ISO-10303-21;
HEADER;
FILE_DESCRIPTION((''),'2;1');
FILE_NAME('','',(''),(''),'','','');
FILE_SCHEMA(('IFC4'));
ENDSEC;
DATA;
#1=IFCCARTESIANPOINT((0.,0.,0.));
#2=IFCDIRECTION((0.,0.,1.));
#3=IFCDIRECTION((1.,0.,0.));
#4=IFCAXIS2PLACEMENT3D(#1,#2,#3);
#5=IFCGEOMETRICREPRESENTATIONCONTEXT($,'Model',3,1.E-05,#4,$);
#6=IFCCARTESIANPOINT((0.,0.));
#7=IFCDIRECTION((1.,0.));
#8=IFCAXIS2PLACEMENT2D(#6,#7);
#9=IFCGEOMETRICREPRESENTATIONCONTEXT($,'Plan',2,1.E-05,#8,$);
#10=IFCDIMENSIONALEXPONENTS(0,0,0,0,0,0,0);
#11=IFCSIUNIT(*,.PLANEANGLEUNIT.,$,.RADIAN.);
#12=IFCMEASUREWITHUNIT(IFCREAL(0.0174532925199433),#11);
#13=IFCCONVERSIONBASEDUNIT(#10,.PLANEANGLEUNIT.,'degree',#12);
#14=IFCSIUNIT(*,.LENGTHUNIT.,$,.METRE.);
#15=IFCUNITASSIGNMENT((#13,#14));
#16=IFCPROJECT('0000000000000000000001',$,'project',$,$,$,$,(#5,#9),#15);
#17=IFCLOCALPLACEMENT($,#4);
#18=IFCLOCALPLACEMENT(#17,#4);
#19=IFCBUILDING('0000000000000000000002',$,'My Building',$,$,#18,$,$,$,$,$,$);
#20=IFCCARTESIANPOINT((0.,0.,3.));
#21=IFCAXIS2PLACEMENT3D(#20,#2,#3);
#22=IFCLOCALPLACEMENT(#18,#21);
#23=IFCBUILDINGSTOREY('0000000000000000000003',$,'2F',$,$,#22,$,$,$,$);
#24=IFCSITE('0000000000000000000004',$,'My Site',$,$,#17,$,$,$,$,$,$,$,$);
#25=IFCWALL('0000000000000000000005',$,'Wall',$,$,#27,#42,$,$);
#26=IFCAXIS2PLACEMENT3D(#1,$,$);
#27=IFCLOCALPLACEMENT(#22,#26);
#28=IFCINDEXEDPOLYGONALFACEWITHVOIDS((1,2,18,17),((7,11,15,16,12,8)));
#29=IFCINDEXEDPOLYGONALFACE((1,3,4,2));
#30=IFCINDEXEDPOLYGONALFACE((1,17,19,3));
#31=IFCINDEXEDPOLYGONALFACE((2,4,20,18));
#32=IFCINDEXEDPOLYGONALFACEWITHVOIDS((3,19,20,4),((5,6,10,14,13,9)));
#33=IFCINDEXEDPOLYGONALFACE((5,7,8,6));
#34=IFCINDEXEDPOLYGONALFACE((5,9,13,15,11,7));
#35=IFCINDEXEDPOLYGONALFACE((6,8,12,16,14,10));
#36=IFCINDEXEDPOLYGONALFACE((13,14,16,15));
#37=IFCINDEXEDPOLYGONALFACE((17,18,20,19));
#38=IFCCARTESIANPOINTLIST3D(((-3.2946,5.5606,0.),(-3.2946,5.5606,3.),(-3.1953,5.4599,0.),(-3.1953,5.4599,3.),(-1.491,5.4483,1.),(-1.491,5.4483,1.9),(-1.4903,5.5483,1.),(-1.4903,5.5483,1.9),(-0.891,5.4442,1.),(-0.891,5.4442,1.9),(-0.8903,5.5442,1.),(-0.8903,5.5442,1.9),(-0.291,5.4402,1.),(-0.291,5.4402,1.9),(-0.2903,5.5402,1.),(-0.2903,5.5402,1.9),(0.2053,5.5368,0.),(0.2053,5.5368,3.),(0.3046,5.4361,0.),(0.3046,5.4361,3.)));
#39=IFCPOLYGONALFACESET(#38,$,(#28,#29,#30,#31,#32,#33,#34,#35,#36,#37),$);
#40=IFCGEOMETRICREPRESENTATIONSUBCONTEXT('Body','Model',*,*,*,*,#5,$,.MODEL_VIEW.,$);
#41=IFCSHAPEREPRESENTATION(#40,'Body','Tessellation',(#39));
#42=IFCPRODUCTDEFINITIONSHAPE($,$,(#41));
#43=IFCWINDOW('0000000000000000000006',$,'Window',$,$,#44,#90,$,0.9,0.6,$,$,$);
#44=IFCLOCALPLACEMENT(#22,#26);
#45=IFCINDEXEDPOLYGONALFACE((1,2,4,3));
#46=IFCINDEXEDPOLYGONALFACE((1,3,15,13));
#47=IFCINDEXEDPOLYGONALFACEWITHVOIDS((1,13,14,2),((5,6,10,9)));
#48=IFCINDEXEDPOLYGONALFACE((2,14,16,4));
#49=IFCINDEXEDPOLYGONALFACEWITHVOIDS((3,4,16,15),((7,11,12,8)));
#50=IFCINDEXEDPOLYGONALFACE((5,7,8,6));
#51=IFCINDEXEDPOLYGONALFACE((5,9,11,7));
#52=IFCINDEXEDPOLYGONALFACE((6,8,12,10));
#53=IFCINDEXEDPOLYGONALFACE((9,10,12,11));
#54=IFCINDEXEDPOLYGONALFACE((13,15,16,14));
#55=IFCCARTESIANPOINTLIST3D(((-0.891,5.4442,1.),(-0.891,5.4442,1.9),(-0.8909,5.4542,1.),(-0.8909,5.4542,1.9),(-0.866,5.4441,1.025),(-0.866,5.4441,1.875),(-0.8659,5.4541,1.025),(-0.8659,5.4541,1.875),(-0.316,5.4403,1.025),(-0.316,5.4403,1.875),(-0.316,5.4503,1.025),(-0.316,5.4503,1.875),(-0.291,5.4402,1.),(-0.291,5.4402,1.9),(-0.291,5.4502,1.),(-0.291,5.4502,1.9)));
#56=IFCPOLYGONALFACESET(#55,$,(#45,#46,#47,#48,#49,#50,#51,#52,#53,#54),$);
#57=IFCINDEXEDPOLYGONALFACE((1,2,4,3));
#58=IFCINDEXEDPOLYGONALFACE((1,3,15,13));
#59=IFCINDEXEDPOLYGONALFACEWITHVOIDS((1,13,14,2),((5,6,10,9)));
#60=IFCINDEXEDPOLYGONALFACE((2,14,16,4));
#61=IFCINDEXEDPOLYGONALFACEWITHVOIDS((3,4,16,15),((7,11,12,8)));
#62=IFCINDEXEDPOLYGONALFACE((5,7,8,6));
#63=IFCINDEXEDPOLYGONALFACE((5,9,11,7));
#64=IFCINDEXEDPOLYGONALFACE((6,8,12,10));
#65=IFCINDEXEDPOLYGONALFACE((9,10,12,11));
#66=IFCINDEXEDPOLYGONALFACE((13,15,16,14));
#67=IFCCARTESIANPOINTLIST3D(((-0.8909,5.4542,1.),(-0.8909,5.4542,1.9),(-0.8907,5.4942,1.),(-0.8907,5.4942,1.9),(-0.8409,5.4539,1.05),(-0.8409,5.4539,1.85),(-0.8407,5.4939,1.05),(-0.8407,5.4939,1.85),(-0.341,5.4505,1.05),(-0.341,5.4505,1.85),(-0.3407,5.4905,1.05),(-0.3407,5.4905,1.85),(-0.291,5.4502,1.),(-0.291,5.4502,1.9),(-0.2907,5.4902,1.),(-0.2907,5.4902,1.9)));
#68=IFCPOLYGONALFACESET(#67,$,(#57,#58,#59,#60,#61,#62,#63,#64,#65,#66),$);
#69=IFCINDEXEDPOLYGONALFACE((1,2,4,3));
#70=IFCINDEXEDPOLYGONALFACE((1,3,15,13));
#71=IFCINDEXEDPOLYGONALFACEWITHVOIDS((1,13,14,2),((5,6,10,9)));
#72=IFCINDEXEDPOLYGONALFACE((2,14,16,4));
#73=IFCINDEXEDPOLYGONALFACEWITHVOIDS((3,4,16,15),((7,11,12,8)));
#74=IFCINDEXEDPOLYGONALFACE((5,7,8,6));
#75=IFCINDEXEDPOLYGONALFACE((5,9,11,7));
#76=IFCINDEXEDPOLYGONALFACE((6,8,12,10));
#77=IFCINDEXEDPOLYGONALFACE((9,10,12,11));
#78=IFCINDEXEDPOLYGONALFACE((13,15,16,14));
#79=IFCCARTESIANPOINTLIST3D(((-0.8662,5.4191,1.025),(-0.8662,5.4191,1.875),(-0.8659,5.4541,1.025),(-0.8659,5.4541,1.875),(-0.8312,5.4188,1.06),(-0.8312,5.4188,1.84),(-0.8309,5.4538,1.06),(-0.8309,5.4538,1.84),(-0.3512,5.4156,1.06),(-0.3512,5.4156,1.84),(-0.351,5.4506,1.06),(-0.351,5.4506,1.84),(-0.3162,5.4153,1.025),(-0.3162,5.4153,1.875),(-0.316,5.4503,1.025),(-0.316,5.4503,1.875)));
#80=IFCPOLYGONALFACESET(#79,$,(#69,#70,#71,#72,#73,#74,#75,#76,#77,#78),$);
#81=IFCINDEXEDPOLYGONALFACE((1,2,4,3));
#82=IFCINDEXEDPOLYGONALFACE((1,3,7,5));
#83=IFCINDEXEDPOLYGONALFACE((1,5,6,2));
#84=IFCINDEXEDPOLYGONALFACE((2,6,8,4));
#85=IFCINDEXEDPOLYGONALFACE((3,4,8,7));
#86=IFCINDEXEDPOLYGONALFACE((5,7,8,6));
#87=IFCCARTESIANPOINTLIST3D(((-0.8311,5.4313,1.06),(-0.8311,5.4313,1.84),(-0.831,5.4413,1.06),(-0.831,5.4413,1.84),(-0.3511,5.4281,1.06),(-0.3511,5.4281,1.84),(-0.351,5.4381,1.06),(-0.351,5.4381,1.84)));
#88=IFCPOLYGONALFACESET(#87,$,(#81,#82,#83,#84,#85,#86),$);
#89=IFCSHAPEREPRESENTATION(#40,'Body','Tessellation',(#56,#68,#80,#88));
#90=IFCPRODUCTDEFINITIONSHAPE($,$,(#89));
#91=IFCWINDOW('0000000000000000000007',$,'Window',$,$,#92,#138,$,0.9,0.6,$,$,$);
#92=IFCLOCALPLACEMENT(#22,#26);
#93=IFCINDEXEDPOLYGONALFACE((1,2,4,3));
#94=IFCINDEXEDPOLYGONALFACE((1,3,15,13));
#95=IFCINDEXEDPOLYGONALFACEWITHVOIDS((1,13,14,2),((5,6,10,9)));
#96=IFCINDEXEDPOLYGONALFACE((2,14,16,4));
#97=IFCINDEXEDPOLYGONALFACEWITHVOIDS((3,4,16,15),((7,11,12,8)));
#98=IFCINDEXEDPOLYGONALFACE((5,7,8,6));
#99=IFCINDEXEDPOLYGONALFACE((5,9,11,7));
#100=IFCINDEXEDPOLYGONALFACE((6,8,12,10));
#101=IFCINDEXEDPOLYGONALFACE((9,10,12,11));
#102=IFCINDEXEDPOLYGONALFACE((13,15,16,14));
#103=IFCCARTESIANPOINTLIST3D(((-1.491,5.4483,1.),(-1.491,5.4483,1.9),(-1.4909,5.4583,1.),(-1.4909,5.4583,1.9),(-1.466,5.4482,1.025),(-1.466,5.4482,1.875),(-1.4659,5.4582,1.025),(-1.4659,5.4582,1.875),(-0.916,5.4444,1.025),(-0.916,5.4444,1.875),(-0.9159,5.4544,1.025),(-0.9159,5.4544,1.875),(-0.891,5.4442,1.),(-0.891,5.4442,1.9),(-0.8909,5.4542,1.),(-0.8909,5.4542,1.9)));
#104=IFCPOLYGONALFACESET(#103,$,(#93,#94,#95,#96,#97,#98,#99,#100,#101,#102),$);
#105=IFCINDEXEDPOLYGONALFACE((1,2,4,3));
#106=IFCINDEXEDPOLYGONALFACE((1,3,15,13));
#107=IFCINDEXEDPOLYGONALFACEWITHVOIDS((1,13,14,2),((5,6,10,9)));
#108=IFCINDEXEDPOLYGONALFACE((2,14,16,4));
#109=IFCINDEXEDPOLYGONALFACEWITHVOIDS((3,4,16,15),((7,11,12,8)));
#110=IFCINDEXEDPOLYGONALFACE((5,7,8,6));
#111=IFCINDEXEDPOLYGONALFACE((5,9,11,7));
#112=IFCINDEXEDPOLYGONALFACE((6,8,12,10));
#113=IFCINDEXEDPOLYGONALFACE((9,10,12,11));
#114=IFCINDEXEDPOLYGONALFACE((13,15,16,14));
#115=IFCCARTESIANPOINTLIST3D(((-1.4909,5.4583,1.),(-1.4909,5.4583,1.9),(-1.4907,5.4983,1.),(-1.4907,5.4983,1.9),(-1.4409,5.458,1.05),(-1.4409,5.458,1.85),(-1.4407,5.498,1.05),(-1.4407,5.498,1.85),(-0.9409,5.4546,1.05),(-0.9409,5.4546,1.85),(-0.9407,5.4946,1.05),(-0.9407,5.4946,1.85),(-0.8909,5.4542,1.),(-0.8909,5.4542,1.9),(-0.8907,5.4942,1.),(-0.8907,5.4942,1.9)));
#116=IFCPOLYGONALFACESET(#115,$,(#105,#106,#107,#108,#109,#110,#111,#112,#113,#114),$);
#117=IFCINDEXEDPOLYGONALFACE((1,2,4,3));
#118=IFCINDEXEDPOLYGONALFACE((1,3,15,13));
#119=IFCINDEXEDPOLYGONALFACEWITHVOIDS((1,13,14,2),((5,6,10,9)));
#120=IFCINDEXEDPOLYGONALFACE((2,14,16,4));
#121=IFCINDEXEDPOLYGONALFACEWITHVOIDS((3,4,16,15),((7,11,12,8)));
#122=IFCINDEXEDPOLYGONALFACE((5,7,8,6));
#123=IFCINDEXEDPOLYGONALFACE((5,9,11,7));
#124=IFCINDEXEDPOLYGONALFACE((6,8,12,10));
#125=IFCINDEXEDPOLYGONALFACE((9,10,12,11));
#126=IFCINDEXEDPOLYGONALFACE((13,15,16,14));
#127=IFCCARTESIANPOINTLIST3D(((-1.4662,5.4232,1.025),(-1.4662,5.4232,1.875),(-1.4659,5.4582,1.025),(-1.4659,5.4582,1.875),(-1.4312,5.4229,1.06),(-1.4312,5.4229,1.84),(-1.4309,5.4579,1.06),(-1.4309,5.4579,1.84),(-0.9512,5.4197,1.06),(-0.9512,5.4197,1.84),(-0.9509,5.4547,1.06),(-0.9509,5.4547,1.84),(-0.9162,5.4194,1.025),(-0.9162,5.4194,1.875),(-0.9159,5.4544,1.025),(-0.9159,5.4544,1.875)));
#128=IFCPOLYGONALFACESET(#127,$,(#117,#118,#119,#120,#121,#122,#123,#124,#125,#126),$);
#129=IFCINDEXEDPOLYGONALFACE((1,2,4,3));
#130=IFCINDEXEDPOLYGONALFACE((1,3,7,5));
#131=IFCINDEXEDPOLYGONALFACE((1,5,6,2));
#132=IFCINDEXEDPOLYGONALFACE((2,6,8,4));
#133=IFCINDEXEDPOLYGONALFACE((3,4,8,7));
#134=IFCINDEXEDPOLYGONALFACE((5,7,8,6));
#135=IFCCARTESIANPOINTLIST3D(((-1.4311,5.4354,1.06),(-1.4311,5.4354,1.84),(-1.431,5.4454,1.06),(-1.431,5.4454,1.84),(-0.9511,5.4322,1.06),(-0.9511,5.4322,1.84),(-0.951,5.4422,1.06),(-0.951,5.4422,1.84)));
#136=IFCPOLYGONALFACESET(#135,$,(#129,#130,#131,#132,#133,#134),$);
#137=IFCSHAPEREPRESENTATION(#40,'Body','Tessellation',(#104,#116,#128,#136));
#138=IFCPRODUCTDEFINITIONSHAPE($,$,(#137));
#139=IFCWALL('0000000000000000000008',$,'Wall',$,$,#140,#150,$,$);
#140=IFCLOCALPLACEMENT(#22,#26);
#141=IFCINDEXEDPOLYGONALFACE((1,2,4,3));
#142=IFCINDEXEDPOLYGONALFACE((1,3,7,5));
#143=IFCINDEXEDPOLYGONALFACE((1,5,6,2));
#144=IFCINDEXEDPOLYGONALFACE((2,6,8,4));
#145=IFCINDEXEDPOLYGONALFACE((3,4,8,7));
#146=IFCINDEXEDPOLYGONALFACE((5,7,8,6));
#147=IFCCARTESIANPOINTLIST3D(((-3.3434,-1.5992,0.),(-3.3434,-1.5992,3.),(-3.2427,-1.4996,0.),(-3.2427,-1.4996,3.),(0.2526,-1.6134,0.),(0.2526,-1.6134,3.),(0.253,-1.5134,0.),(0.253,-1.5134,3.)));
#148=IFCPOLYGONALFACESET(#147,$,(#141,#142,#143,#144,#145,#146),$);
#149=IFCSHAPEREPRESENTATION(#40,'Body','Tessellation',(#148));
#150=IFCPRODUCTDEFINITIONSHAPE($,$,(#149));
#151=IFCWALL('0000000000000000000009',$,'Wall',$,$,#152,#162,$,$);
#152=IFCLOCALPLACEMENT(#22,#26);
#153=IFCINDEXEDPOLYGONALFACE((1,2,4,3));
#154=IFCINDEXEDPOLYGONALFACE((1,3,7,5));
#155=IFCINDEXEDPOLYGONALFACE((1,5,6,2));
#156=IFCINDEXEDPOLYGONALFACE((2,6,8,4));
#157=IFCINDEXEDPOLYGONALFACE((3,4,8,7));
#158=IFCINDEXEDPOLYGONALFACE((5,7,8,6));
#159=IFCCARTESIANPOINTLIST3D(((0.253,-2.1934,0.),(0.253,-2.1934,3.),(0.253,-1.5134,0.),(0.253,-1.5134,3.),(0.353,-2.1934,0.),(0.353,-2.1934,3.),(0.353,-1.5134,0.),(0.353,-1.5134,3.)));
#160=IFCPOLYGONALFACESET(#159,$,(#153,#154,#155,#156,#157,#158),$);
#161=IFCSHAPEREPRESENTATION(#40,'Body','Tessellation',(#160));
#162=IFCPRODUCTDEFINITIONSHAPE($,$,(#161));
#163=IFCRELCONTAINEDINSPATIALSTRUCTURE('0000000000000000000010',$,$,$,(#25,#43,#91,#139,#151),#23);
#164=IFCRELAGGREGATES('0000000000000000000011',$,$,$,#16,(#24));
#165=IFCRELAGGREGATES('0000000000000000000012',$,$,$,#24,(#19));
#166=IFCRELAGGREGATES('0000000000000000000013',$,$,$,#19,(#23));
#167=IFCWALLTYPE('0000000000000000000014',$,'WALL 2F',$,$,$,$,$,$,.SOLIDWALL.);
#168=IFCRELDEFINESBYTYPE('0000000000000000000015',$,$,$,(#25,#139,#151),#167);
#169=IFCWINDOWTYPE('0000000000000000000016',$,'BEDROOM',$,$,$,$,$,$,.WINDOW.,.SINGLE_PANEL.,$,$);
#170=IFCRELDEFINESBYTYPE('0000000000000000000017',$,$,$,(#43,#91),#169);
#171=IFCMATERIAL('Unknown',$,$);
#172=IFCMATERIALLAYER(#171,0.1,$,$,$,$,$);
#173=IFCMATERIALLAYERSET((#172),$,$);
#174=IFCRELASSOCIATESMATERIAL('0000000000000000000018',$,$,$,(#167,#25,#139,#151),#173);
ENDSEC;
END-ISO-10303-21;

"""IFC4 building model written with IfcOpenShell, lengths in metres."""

from ifc_helpers import new_model, entity, si_unit, converted_unit, frame, origin_with_axes, origin_2d_with_axis, place, context, subcontext, project, spatial, line, indexed_curve, outline, extrude, shape, source, transform, mapped, material, layer, layer_set, layer_usage, type_object, type_shapes, element, fill, save


model = new_model("IFC4")

# Units and contexts
model_context = context("Model", 3, precision=1e-05, world=origin_with_axes())
plan_context = context("Plan", 2, precision=1e-05, world=origin_2d_with_axis())
body_context_1 = subcontext(model_context, "Body", "Model", "MODEL_VIEW")
body_context_2 = subcontext(plan_context, "Body", "Plan", "PLAN_VIEW")
ifc_project = project(units=[converted_unit("PLANEANGLEUNIT", "degree", entity("IfcReal", 0.0174532925199433), si_unit("PLANEANGLEUNIT", "RADIAN"), dimensions=[0, 0, 0, 0, 0, 0, 0]), si_unit("LENGTHUNIT", "METRE")], contexts=[model_context, plan_context])

# Site, building, storey
site_placement = place(None, origin_with_axes())
site = spatial("IfcSite", under=ifc_project, at=site_placement, Name="My Site")
building_placement = place(site_placement, origin_with_axes())
building = spatial("IfcBuilding", under=site, at=building_placement, Name="My Building")
storey_placement = place(building_placement, frame((0.0, 0.0, 3.0), z_axis=(0.0, 0.0, 1.0), x_axis=(1.0, 0.0, 0.0)))
storey = spatial("IfcBuildingStorey", under=building, at=storey_placement, Name="2F")

# Shared definitions
ifc_material = material(Name="Unknown")

# Shared definitions
ifc_layer_1 = layer(ifc_material, 0.1)
ifc_layer_set_1 = layer_set([ifc_layer_1])
wall_type = type_object("IfcWallType", Name="WALL 2F", PredefinedType="SOLIDWALL", material=ifc_layer_set_1)

# Wall, openings, windows
ifc_layer_usage_1 = layer_usage(ifc_layer_set_1, "AXIS2", "POSITIVE", 0.0)
wall_1_placement = place(storey_placement, frame((0.2053, 5.5368, 0.0), z_axis=(0.0, 0.0, 1.0), x_axis=(-0.999977, 0.006815, 0.0)))
wall_1 = element("IfcWall", 1, at=wall_1_placement, inside=storey, type_object=wall_type, material=ifc_layer_usage_1, Name="Wall", context=body_context_1, shape_type="SweptSolid", body=[
    extrude(outline(indexed_curve([(0.0, 0.0), (-0.1, 0.1), (3.4, 0.1), (3.5, 0.0)], segments=[line(1, 2, 3, 4, 1)])), origin_with_axes(), (0.0, 0.0, 1.0), 3.0),
])
shared_shape_1 = source(origin_with_axes(), body_context_1, "Body", "SweptSolid", [
    extrude(outline(indexed_curve([(0.0, 0.0), (0.6, 0.0), (0.6, 0.9), (0.0, 0.9)], segments=[line(1, 2, 3, 4, 1)])), frame((0.0, -0.6, 0.0), z_axis=(0.0, -1.0, 0.0), x_axis=(1.0, 0.0, 0.0)), (0.0, 0.0, -1.0), 1.2),
])
opening_1_placement = place(wall_1_placement, frame((0.4957, 0.0, 1.0), z_axis=(0.0, 0.0, 1.0), x_axis=(1.0, 0.0, 0.0)))
opening_1 = element("IfcOpeningElement", 2, at=opening_1_placement, cuts=wall_1, PredefinedType="OPENING", context=body_context_1, shape_type="MappedRepresentation", body=[
    mapped(shared_shape_1, transform((0.0, 0.0, 0.0), x_axis=(1.0, 0.0, 0.0), y_axis=(0.0, 1.0, 0.0), z_axis=(0.0, 0.0, 1.0), scale=1.0)),
])
opening_2_placement = place(wall_1_placement, frame((1.0957, 0.0, 1.0), z_axis=(0.0, 0.0, 1.0), x_axis=(1.0, 0.0, 0.0)))
opening_2 = element("IfcOpeningElement", 3, at=opening_2_placement, cuts=wall_1, PredefinedType="OPENING", context=body_context_1, shape_type="MappedRepresentation", body=[
    mapped(shared_shape_1, transform((0.0, 0.0, 0.0), x_axis=(1.0, 0.0, 0.0), y_axis=(0.0, 1.0, 0.0), z_axis=(0.0, 0.0, 1.0), scale=1.0)),
])
window_type_1 = type_object("IfcWindowType", Name="BEDROOM", PartitioningType="SINGLE_PANEL", PredefinedType="WINDOW")
shared_shape_2 = source(origin_with_axes(), body_context_1, "Body", "SweptSolid", [
    extrude(outline(indexed_curve([(0.0, 0.0), (0.6, 0.0), (0.6, 0.9), (0.0, 0.9)], segments=[line(1, 2, 3, 4, 1)]), holes=[indexed_curve([(0.025, 0.025), (0.575, 0.025), (0.575, 0.875), (0.025, 0.875)], segments=[line(1, 2, 3, 4, 1)])]), frame((0.0, 0.09, 0.0), z_axis=(0.0, -1.0, 0.0), x_axis=(1.0, 0.0, 0.0)), (0.0, 0.0, -1.0), 0.01),
    extrude(outline(indexed_curve([(0.0, 0.0), (0.6, 0.0), (0.6, 0.9), (0.0, 0.9)], segments=[line(1, 2, 3, 4, 1)]), holes=[indexed_curve([(0.05, 0.05), (0.55, 0.05), (0.55, 0.85), (0.05, 0.85)], segments=[line(1, 2, 3, 4, 1)])]), frame((0.0, 0.05, 0.0), z_axis=(0.0, -1.0, 0.0), x_axis=(1.0, 0.0, 0.0)), (0.0, 0.0, -1.0), 0.04),
    extrude(outline(indexed_curve([(0.0, 0.0), (0.55, 0.0), (0.55, 0.85), (0.0, 0.85)], segments=[line(1, 2, 3, 4, 1)]), holes=[indexed_curve([(0.035, 0.035), (0.515, 0.035), (0.515, 0.815), (0.035, 0.815)], segments=[line(1, 2, 3, 4, 1)])]), frame((0.025, 0.09, 0.025), z_axis=(0.0, -1.0, 0.0), x_axis=(1.0, 0.0, 0.0)), (0.0, 0.0, -1.0), 0.035),
    extrude(outline(indexed_curve([(0.035, 0.035), (0.515, 0.035), (0.515, 0.815), (0.035, 0.815)], segments=[line(1, 2, 3, 4, 1)])), frame((0.025, 0.1025, 0.025), z_axis=(0.0, -1.0, 0.0), x_axis=(1.0, 0.0, 0.0)), (0.0, 0.0, -1.0), 0.01),
])
shared_shape_3 = source(origin_with_axes(), body_context_2, "Body", "Curve2D", [
    entity("IfcIndexedPolyCurve", entity("IfcCartesianPointList2D", [[0.05, 0.05], [0.55, 0.05]])),
    entity("IfcIndexedPolyCurve", entity("IfcCartesianPointList2D", [[0.0, 0.1], [0.025, 0.1], [0.025, 0.09], [0.05, 0.09], [0.05, 0.05], [0.0, 0.05]]), [entity("IfcLineIndex", [1, 2, 3, 4, 5, 6, 1])]),
    entity("IfcIndexedPolyCurve", entity("IfcCartesianPointList2D", [[0.6, 0.1], [0.575, 0.1], [0.575, 0.09], [0.55, 0.09], [0.55, 0.05], [0.6, 0.05]]), [entity("IfcLineIndex", [1, 2, 3, 4, 5, 6, 1])]),
    entity("IfcIndexedPolyCurve", entity("IfcCartesianPointList2D", [[0.025, 0.09], [0.06, 0.09], [0.06, 0.125], [0.025, 0.125]]), [entity("IfcLineIndex", [1, 2, 3, 4, 1])]),
    entity("IfcIndexedPolyCurve", entity("IfcCartesianPointList2D", [[0.575, 0.09], [0.54, 0.09], [0.54, 0.125], [0.575, 0.125]]), [entity("IfcLineIndex", [1, 2, 3, 4, 1])]),
    entity("IfcIndexedPolyCurve", entity("IfcCartesianPointList2D", [[0.06, 0.09], [0.54, 0.09]])),
    entity("IfcIndexedPolyCurve", entity("IfcCartesianPointList2D", [[0.06, 0.125], [0.54, 0.125]])),
    entity("IfcIndexedPolyCurve", entity("IfcCartesianPointList2D", [[0.06, 0.1075], [0.54, 0.1075]])),
])
type_shapes(window_type_1, [shared_shape_2, shared_shape_3])
window_1_placement = place(opening_1_placement, frame((0.0, 0.0, 0.0), z_axis=(0.0, 0.0, 1.0), x_axis=(1.0, 0.0, 0.0)))
window_1 = element("IfcWindow", 4, at=window_1_placement, inside=storey, type_object=window_type_1, Name="Window", OverallHeight=0.9, OverallWidth=0.6, shapes=[
    shape(body_context_1, "Body", "MappedRepresentation", [mapped(shared_shape_2, transform((0.0, 0.0, 0.0), x_axis=(1.0, 0.0, 0.0), y_axis=(0.0, 1.0, 0.0), z_axis=(0.0, 0.0, 1.0), scale=1.0))]),
    shape(body_context_2, "Body", "MappedRepresentation", [mapped(shared_shape_3, transform((0.0, 0.0, 0.0), x_axis=(1.0, 0.0, 0.0), y_axis=(0.0, 1.0, 0.0), z_axis=(0.0, 0.0, 1.0), scale=1.0))]),
])
fill(opening_1, window_1)
window_2_placement = place(opening_2_placement, frame((0.0, 0.0, 0.0), z_axis=(0.0, 0.0, 1.0), x_axis=(1.0, 0.0, 0.0)))
window_2 = element("IfcWindow", 5, at=window_2_placement, inside=storey, type_object=window_type_1, Name="Window", OverallHeight=0.9, OverallWidth=0.6, shapes=[
    shape(body_context_1, "Body", "MappedRepresentation", [mapped(shared_shape_2, transform((0.0, 0.0, 0.0), x_axis=(1.0, 0.0, 0.0), y_axis=(0.0, 1.0, 0.0), z_axis=(0.0, 0.0, 1.0), scale=1.0))]),
    shape(body_context_2, "Body", "MappedRepresentation", [mapped(shared_shape_3, transform((0.0, 0.0, 0.0), x_axis=(1.0, 0.0, 0.0), y_axis=(0.0, 1.0, 0.0), z_axis=(0.0, 0.0, 1.0), scale=1.0))]),
])
fill(opening_2, window_2)

# Walls
ifc_layer_usage_2 = layer_usage(ifc_layer_set_1, "AXIS2", "POSITIVE", 0.0)
wall_2_placement = place(storey_placement, frame((-3.3434, -1.5992, 0.0), z_axis=(0.0, 0.0, 1.0), x_axis=(0.999992, -0.00396, 0.0)))
element("IfcWall", 6, at=wall_2_placement, inside=storey, type_object=wall_type, material=ifc_layer_usage_2, Name="Wall", context=body_context_1, shape_type="SweptSolid", body=[
    extrude(outline(indexed_curve([(0.0, 0.0), (0.1003, 0.1), (3.5961, 0.1), (3.5961, 0.0)], segments=[line(1, 2, 3, 4, 1)])), origin_with_axes(), (0.0, 0.0, 1.0), 3.0),
])
ifc_layer_usage_3 = layer_usage(ifc_layer_set_1, "AXIS2", "POSITIVE", 0.0)
wall_3_placement = place(storey_placement, frame((0.253, -1.5134, 0.0), z_axis=(0.0, 0.0, 1.0), x_axis=(0.0, -1.0, 0.0)))
element("IfcWall", 7, at=wall_3_placement, inside=storey, type_object=wall_type, material=ifc_layer_usage_3, Name="Wall", context=body_context_1, shape_type="SweptSolid", body=[
    extrude(outline(indexed_curve([(0.0, 0.0), (0.0, 0.1), (0.68, 0.1), (0.68, 0.0)], segments=[line(1, 2, 3, 4, 1)])), origin_with_axes(), (0.0, 0.0, 1.0), 3.0),
])

save(model, "model.ifc")
